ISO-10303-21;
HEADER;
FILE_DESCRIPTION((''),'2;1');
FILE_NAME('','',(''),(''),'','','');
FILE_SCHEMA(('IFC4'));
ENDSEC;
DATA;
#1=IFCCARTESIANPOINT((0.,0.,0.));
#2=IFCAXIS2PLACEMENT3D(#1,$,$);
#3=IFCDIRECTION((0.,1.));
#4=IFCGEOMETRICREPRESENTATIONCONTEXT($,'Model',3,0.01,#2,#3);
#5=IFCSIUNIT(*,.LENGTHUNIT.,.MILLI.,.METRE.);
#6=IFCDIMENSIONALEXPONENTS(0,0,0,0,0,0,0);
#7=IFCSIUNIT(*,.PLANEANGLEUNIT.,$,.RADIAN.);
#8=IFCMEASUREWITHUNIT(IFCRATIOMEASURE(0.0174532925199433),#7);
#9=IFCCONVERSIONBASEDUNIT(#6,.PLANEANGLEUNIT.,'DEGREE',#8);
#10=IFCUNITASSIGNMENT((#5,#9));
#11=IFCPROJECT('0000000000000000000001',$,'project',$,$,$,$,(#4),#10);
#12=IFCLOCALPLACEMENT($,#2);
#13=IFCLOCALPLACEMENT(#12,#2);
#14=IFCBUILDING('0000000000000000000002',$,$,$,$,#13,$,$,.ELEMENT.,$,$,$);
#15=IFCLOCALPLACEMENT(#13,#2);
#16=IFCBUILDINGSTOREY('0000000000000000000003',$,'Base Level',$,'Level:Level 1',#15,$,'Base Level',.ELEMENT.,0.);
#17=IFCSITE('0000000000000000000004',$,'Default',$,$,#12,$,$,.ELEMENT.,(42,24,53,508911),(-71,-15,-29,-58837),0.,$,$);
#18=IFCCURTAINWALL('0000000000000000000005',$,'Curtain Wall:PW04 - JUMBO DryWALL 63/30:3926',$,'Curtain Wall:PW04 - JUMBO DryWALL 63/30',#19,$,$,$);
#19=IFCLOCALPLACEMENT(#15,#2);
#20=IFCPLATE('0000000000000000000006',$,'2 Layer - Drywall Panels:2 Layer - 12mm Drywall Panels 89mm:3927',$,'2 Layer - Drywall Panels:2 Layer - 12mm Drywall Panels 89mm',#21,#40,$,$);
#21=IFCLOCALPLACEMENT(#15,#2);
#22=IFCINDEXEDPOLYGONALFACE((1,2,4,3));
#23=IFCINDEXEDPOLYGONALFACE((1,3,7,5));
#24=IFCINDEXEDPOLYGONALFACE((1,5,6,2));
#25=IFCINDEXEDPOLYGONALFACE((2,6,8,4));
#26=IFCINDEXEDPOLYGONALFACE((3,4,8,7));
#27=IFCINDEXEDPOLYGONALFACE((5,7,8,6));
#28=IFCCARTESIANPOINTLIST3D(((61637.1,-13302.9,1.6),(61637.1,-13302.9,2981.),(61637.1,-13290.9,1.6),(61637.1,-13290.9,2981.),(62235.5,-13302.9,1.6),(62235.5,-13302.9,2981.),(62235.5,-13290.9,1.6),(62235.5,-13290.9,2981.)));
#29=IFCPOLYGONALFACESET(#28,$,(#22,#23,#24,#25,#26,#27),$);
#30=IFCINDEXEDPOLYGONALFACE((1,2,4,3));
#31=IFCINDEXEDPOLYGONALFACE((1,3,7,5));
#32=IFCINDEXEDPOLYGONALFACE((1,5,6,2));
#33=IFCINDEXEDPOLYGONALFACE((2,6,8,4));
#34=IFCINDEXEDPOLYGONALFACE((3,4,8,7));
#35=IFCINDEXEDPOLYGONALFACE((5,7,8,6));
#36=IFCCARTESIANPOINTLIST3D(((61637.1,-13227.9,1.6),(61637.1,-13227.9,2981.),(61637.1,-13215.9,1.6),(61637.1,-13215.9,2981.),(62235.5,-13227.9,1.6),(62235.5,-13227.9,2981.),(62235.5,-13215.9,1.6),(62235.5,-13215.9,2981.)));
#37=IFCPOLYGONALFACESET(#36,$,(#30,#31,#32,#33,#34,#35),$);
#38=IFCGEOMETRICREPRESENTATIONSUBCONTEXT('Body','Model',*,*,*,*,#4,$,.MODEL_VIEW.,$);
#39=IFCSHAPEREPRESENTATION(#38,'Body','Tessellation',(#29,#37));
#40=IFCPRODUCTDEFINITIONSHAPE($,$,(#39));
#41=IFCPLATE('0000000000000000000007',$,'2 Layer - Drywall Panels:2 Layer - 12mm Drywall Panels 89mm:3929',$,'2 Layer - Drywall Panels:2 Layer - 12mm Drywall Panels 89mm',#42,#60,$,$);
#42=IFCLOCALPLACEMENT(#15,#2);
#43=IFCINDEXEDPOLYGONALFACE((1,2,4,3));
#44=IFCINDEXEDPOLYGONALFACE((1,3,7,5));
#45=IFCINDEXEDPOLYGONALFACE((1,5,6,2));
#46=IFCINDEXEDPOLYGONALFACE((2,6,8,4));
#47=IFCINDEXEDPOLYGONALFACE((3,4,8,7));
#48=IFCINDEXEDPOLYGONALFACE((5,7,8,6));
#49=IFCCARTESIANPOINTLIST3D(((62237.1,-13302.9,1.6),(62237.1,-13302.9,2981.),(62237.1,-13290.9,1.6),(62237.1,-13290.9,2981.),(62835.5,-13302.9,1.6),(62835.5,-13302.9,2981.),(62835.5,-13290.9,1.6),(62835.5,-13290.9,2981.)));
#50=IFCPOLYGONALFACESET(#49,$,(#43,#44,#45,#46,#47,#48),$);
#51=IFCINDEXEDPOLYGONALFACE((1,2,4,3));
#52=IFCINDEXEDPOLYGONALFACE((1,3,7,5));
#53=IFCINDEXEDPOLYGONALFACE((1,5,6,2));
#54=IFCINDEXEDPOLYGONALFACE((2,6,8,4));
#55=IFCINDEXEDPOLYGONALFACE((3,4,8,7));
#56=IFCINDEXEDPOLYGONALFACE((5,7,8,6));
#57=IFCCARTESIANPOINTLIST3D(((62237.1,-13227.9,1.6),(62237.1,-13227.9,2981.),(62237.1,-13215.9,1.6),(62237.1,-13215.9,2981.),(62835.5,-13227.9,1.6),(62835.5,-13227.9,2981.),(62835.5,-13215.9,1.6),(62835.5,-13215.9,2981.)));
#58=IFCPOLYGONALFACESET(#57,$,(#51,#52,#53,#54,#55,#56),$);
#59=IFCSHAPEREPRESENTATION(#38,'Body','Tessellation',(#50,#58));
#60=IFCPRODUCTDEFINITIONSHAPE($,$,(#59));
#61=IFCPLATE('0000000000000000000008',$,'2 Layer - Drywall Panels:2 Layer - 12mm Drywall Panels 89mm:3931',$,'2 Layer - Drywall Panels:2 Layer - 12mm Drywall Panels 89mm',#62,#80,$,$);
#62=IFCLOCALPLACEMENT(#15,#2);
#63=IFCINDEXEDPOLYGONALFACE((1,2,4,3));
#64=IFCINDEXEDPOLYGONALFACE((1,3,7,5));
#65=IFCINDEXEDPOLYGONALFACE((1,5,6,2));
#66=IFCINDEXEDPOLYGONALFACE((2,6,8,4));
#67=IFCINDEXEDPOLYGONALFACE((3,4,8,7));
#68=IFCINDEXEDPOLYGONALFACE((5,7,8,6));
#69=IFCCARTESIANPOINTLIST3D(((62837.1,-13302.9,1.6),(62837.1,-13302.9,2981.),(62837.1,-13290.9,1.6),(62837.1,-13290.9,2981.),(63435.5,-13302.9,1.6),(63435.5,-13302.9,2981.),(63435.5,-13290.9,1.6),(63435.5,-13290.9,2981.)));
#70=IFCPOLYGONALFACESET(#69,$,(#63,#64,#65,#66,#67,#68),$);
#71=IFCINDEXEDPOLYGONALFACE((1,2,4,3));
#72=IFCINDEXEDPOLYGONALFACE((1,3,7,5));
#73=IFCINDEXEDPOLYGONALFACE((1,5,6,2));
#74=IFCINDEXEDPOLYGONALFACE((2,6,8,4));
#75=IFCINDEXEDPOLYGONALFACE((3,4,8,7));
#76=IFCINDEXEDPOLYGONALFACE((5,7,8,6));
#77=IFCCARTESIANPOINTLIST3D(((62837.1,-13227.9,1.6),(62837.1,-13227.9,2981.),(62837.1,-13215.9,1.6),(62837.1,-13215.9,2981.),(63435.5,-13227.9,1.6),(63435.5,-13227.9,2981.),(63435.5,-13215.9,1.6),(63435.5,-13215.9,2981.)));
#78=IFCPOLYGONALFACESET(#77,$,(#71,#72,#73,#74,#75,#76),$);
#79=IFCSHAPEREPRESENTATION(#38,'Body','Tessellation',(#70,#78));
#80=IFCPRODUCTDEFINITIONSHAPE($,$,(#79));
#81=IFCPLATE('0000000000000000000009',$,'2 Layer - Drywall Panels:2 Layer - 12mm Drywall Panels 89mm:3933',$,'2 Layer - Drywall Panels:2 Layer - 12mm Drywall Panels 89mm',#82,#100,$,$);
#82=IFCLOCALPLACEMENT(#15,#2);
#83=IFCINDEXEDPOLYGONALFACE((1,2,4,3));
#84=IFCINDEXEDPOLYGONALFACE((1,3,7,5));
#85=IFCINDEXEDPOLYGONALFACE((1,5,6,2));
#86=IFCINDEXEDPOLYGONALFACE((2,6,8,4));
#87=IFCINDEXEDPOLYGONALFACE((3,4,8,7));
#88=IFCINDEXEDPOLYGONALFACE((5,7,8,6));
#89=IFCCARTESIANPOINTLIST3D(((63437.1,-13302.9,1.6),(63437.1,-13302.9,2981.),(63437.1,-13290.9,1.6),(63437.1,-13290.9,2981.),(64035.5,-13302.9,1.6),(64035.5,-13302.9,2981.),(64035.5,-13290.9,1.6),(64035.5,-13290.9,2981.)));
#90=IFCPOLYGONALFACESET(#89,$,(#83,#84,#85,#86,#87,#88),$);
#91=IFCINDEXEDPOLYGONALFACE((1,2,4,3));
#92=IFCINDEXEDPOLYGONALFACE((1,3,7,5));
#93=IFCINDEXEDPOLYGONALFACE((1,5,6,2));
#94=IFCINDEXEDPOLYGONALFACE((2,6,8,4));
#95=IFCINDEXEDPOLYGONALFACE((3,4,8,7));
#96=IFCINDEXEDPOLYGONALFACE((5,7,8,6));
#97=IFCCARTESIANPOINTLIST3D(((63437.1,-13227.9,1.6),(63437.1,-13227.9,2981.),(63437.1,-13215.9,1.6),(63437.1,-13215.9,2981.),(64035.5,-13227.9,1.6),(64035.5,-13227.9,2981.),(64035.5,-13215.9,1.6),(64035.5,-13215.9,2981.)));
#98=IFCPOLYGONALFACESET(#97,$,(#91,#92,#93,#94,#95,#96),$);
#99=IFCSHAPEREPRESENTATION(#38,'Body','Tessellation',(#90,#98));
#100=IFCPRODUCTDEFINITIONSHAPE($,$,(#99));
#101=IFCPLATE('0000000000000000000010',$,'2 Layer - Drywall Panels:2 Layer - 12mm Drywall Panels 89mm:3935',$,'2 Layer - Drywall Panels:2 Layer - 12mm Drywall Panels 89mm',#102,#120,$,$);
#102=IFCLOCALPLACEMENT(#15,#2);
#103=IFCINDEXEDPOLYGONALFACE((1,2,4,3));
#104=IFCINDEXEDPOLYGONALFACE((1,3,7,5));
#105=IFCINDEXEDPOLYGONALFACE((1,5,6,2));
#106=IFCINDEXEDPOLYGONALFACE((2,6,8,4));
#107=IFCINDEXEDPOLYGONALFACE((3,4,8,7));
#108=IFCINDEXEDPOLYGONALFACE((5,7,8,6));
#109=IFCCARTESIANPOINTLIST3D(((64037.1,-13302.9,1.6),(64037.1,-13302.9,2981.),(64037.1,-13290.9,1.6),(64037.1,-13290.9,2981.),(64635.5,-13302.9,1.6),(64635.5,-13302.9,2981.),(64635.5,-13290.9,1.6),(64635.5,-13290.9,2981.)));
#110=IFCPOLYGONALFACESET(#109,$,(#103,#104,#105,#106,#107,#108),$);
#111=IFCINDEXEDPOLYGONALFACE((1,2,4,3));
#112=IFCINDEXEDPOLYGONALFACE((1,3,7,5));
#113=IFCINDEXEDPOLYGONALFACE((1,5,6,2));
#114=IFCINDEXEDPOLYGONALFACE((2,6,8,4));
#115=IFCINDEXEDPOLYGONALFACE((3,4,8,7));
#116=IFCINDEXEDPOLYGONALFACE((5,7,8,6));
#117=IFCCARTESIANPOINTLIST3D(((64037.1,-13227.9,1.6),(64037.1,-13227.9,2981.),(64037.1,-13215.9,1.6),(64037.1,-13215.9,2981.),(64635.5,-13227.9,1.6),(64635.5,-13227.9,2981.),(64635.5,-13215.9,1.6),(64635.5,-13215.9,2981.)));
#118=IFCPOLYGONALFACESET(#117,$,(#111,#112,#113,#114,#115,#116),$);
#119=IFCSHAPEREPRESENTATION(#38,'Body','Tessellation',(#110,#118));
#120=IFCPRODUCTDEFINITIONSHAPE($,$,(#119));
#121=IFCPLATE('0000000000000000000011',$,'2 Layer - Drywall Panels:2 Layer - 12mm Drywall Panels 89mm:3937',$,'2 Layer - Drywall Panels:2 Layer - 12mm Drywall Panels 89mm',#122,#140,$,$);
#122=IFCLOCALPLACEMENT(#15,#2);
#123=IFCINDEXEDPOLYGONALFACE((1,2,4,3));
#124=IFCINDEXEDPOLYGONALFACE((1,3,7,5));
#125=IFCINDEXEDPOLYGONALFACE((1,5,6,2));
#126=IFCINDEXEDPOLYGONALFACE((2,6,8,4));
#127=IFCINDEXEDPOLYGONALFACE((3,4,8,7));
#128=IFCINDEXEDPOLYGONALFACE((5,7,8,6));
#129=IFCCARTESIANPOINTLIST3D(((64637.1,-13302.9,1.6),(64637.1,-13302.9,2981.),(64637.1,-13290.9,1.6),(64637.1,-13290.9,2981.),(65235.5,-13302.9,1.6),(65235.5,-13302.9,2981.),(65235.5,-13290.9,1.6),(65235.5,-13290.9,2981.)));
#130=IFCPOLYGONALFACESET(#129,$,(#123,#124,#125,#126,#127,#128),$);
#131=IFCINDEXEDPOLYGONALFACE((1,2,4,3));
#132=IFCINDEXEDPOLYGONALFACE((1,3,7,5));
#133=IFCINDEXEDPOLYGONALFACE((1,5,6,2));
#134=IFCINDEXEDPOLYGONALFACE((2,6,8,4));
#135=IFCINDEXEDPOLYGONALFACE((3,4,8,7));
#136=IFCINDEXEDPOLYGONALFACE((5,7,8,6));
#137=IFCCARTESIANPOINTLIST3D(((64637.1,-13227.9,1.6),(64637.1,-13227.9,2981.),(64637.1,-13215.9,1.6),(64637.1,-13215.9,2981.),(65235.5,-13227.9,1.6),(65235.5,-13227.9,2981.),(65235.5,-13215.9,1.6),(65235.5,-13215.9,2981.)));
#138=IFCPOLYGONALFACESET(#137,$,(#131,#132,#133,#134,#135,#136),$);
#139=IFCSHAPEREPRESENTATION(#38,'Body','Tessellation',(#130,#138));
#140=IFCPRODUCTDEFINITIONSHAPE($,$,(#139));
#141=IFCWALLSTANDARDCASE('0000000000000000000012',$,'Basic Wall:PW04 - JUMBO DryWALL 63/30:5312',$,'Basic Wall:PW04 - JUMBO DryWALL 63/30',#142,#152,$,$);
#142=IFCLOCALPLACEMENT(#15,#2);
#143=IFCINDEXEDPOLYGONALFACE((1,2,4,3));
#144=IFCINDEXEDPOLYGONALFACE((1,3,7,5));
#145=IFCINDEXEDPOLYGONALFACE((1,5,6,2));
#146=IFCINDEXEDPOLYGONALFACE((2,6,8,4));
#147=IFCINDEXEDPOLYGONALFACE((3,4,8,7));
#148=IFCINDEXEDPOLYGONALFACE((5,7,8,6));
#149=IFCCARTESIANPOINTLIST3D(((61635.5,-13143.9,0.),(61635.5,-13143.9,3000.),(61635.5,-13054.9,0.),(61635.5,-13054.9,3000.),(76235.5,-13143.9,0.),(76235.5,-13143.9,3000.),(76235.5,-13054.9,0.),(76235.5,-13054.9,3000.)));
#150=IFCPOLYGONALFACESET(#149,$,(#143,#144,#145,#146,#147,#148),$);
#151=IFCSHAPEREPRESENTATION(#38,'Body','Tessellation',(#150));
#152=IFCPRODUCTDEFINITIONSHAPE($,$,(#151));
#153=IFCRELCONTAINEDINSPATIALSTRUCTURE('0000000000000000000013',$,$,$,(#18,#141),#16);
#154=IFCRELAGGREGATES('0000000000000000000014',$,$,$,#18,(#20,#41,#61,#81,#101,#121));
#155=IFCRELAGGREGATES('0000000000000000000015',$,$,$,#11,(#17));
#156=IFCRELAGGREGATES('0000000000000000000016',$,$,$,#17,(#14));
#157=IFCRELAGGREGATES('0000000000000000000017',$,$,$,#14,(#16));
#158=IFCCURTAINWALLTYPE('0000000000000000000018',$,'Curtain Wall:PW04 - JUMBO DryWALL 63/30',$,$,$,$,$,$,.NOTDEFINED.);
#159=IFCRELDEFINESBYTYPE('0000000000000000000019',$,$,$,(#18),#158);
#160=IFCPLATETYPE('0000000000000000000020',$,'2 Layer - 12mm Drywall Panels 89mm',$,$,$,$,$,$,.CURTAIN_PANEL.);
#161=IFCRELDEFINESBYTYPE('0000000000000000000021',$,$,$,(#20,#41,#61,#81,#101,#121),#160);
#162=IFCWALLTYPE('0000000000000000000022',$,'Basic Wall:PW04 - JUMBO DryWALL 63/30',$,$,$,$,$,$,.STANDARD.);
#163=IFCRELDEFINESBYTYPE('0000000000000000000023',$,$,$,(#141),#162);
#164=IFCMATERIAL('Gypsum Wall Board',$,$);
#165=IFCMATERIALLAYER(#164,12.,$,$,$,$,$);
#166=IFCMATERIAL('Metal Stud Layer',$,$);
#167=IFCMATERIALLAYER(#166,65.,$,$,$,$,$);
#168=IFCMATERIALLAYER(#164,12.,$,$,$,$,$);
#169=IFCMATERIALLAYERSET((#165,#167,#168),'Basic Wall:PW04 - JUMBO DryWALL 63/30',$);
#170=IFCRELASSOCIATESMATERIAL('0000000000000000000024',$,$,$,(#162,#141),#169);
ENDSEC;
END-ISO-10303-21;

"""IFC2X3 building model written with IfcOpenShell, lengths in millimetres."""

from ifc_helpers import new_model, entity, si_unit, converted_unit, direction, frame, frame_2d, origin, place, context, subcontext, project, spatial, rectangle, extrude, source, transform, mapped, material, layer, layer_set, layer_usage, type_object, type_shapes, element, aggregate, save


model = new_model("IFC2X3")

# Units and contexts
model_context = context("Model", 3, precision=0.01, world=origin(), true_north=direction((0.0, 1.0)))
body_context = subcontext(model_context, "Body", "Model", "MODEL_VIEW")
ifc_project = project(units=[si_unit("LENGTHUNIT", "METRE", prefix="MILLI"), converted_unit("PLANEANGLEUNIT", "DEGREE", entity("IfcRatioMeasure", 0.0174532925199433), si_unit("PLANEANGLEUNIT", "RADIAN"), dimensions=[0, 0, 0, 0, 0, 0, 0])], contexts=[model_context])

# Site, building, storey
site_placement = place(None, origin())
site = spatial("IfcSite", under=ifc_project, at=site_placement, Name="Default", CompositionType="ELEMENT", RefLatitude=(42, 24, 53, 508911), RefLongitude=(-71, -15, -29, -58837), RefElevation=0.0)
building_placement = place(site_placement, origin())
building = spatial("IfcBuilding", under=site, at=building_placement, CompositionType="ELEMENT")
storey_placement = place(building_placement, origin())
storey = spatial("IfcBuildingStorey", under=building, at=storey_placement, Name="Base Level", ObjectType="Level:Level 1", LongName="Base Level", CompositionType="ELEMENT", Elevation=0.0)

# Curtain wall, plates
curtain_wall_type = type_object("IfcCurtainWallType", Name="Curtain Wall:PW04 - JUMBO DryWALL 63/30", PredefinedType="NOTDEFINED")
curtain_wall_placement = place(building_placement, origin())
curtain_wall = element("IfcCurtainWall", 1, at=curtain_wall_placement, inside=storey, type_object=curtain_wall_type, Name="Curtain Wall:PW04 - JUMBO DryWALL 63/30:3926", ObjectType="Curtain Wall:PW04 - JUMBO DryWALL 63/30")
plate_type = type_object("IfcPlateType", Name="2 Layer - 12mm Drywall Panels 89mm", PredefinedType="CURTAIN_PANEL")
shared_shape_1 = source(origin(), body_context, "Body", "SweptSolid", [
    extrude(rectangle(XDim=598.4, YDim=12.0, at=frame_2d((0.0, 0.0), x_axis=(1.0, 0.0))), frame((0.0, -37.5, 0.0), z_axis=(0.0, 0.0, 1.0), x_axis=(-1.0, 0.0, 0.0)), (0.0, 0.0, 1.0), 2979.4),
    extrude(rectangle(XDim=12.0, YDim=598.4, at=frame_2d((0.0, 0.0), x_axis=(1.0, 0.0))), frame((0.0, 37.5, 0.0), z_axis=(0.0, 0.0, 1.0), x_axis=(0.0, 1.0, 0.0)), (0.0, 0.0, 1.0), 2979.4),
])
type_shapes(plate_type, [shared_shape_1])
plate_1_placement = place(curtain_wall_placement, frame((61936.3, -13259.4, 1.6)))
plate_1 = element("IfcPlate", 2, at=plate_1_placement, type_object=plate_type, Name="2 Layer - Drywall Panels:2 Layer - 12mm Drywall Panels 89mm:3927", ObjectType="2 Layer - Drywall Panels:2 Layer - 12mm Drywall Panels 89mm", context=body_context, shape_type="MappedRepresentation", body=[
    mapped(shared_shape_1, transform((0.0, 0.0, 0.0), scale=1.0)),
])
plate_2_placement = place(curtain_wall_placement, frame((62536.3, -13259.4, 1.6)))
plate_2 = element("IfcPlate", 3, at=plate_2_placement, type_object=plate_type, Name="2 Layer - Drywall Panels:2 Layer - 12mm Drywall Panels 89mm:3929", ObjectType="2 Layer - Drywall Panels:2 Layer - 12mm Drywall Panels 89mm", context=body_context, shape_type="MappedRepresentation", body=[
    mapped(shared_shape_1, transform((0.0, 0.0, 0.0), scale=1.0)),
])
plate_3_placement = place(curtain_wall_placement, frame((63136.3, -13259.4, 1.6)))
plate_3 = element("IfcPlate", 4, at=plate_3_placement, type_object=plate_type, Name="2 Layer - Drywall Panels:2 Layer - 12mm Drywall Panels 89mm:3931", ObjectType="2 Layer - Drywall Panels:2 Layer - 12mm Drywall Panels 89mm", context=body_context, shape_type="MappedRepresentation", body=[
    mapped(shared_shape_1, transform((0.0, 0.0, 0.0), scale=1.0)),
])
plate_4_placement = place(curtain_wall_placement, frame((63736.3, -13259.4, 1.6)))
plate_4 = element("IfcPlate", 5, at=plate_4_placement, type_object=plate_type, Name="2 Layer - Drywall Panels:2 Layer - 12mm Drywall Panels 89mm:3933", ObjectType="2 Layer - Drywall Panels:2 Layer - 12mm Drywall Panels 89mm", context=body_context, shape_type="MappedRepresentation", body=[
    mapped(shared_shape_1, transform((0.0, 0.0, 0.0), scale=1.0)),
])
plate_5_placement = place(curtain_wall_placement, frame((64336.3, -13259.4, 1.6)))
plate_5 = element("IfcPlate", 6, at=plate_5_placement, type_object=plate_type, Name="2 Layer - Drywall Panels:2 Layer - 12mm Drywall Panels 89mm:3935", ObjectType="2 Layer - Drywall Panels:2 Layer - 12mm Drywall Panels 89mm", context=body_context, shape_type="MappedRepresentation", body=[
    mapped(shared_shape_1, transform((0.0, 0.0, 0.0), scale=1.0)),
])
plate_6_placement = place(curtain_wall_placement, frame((64936.3, -13259.4, 1.6)))
plate_6 = element("IfcPlate", 7, at=plate_6_placement, type_object=plate_type, Name="2 Layer - Drywall Panels:2 Layer - 12mm Drywall Panels 89mm:3937", ObjectType="2 Layer - Drywall Panels:2 Layer - 12mm Drywall Panels 89mm", context=body_context, shape_type="MappedRepresentation", body=[
    mapped(shared_shape_1, transform((0.0, 0.0, 0.0), scale=1.0)),
])
aggregate(curtain_wall, [plate_1, plate_2, plate_3, plate_4, plate_5, plate_6])

# Wall
ifc_material_1 = material(Name="Gypsum Wall Board")
ifc_layer_1 = layer(ifc_material_1, 12.0)
ifc_material_2 = material(Name="Metal Stud Layer")
ifc_layer_2 = layer(ifc_material_2, 65.0)
ifc_layer_3 = layer(ifc_material_1, 12.0)
ifc_layer_set = layer_set([ifc_layer_1, ifc_layer_2, ifc_layer_3], Name="Basic Wall:PW04 - JUMBO DryWALL 63/30")
ifc_layer_usage = layer_usage(ifc_layer_set, "AXIS2", "NEGATIVE", 44.5)
wall_type = type_object("IfcWallType", Name="Basic Wall:PW04 - JUMBO DryWALL 63/30", PredefinedType="STANDARD", material=ifc_layer_set)
wall_placement = place(building_placement, frame((61635.5, -13099.4, 0.0)))
element("IfcWallStandardCase", 8, at=wall_placement, inside=storey, type_object=wall_type, material=ifc_layer_usage, Name="Basic Wall:PW04 - JUMBO DryWALL 63/30:5312", ObjectType="Basic Wall:PW04 - JUMBO DryWALL 63/30", context=body_context, shape_type="SweptSolid", body=[
    extrude(rectangle(XDim=14600.0, YDim=89.0, at=frame_2d((7300.0, 0.0), x_axis=(-1.0, 0.0))), origin(), (0.0, 0.0, 1.0), 3000.0),
])

save(model, "model.ifc")
